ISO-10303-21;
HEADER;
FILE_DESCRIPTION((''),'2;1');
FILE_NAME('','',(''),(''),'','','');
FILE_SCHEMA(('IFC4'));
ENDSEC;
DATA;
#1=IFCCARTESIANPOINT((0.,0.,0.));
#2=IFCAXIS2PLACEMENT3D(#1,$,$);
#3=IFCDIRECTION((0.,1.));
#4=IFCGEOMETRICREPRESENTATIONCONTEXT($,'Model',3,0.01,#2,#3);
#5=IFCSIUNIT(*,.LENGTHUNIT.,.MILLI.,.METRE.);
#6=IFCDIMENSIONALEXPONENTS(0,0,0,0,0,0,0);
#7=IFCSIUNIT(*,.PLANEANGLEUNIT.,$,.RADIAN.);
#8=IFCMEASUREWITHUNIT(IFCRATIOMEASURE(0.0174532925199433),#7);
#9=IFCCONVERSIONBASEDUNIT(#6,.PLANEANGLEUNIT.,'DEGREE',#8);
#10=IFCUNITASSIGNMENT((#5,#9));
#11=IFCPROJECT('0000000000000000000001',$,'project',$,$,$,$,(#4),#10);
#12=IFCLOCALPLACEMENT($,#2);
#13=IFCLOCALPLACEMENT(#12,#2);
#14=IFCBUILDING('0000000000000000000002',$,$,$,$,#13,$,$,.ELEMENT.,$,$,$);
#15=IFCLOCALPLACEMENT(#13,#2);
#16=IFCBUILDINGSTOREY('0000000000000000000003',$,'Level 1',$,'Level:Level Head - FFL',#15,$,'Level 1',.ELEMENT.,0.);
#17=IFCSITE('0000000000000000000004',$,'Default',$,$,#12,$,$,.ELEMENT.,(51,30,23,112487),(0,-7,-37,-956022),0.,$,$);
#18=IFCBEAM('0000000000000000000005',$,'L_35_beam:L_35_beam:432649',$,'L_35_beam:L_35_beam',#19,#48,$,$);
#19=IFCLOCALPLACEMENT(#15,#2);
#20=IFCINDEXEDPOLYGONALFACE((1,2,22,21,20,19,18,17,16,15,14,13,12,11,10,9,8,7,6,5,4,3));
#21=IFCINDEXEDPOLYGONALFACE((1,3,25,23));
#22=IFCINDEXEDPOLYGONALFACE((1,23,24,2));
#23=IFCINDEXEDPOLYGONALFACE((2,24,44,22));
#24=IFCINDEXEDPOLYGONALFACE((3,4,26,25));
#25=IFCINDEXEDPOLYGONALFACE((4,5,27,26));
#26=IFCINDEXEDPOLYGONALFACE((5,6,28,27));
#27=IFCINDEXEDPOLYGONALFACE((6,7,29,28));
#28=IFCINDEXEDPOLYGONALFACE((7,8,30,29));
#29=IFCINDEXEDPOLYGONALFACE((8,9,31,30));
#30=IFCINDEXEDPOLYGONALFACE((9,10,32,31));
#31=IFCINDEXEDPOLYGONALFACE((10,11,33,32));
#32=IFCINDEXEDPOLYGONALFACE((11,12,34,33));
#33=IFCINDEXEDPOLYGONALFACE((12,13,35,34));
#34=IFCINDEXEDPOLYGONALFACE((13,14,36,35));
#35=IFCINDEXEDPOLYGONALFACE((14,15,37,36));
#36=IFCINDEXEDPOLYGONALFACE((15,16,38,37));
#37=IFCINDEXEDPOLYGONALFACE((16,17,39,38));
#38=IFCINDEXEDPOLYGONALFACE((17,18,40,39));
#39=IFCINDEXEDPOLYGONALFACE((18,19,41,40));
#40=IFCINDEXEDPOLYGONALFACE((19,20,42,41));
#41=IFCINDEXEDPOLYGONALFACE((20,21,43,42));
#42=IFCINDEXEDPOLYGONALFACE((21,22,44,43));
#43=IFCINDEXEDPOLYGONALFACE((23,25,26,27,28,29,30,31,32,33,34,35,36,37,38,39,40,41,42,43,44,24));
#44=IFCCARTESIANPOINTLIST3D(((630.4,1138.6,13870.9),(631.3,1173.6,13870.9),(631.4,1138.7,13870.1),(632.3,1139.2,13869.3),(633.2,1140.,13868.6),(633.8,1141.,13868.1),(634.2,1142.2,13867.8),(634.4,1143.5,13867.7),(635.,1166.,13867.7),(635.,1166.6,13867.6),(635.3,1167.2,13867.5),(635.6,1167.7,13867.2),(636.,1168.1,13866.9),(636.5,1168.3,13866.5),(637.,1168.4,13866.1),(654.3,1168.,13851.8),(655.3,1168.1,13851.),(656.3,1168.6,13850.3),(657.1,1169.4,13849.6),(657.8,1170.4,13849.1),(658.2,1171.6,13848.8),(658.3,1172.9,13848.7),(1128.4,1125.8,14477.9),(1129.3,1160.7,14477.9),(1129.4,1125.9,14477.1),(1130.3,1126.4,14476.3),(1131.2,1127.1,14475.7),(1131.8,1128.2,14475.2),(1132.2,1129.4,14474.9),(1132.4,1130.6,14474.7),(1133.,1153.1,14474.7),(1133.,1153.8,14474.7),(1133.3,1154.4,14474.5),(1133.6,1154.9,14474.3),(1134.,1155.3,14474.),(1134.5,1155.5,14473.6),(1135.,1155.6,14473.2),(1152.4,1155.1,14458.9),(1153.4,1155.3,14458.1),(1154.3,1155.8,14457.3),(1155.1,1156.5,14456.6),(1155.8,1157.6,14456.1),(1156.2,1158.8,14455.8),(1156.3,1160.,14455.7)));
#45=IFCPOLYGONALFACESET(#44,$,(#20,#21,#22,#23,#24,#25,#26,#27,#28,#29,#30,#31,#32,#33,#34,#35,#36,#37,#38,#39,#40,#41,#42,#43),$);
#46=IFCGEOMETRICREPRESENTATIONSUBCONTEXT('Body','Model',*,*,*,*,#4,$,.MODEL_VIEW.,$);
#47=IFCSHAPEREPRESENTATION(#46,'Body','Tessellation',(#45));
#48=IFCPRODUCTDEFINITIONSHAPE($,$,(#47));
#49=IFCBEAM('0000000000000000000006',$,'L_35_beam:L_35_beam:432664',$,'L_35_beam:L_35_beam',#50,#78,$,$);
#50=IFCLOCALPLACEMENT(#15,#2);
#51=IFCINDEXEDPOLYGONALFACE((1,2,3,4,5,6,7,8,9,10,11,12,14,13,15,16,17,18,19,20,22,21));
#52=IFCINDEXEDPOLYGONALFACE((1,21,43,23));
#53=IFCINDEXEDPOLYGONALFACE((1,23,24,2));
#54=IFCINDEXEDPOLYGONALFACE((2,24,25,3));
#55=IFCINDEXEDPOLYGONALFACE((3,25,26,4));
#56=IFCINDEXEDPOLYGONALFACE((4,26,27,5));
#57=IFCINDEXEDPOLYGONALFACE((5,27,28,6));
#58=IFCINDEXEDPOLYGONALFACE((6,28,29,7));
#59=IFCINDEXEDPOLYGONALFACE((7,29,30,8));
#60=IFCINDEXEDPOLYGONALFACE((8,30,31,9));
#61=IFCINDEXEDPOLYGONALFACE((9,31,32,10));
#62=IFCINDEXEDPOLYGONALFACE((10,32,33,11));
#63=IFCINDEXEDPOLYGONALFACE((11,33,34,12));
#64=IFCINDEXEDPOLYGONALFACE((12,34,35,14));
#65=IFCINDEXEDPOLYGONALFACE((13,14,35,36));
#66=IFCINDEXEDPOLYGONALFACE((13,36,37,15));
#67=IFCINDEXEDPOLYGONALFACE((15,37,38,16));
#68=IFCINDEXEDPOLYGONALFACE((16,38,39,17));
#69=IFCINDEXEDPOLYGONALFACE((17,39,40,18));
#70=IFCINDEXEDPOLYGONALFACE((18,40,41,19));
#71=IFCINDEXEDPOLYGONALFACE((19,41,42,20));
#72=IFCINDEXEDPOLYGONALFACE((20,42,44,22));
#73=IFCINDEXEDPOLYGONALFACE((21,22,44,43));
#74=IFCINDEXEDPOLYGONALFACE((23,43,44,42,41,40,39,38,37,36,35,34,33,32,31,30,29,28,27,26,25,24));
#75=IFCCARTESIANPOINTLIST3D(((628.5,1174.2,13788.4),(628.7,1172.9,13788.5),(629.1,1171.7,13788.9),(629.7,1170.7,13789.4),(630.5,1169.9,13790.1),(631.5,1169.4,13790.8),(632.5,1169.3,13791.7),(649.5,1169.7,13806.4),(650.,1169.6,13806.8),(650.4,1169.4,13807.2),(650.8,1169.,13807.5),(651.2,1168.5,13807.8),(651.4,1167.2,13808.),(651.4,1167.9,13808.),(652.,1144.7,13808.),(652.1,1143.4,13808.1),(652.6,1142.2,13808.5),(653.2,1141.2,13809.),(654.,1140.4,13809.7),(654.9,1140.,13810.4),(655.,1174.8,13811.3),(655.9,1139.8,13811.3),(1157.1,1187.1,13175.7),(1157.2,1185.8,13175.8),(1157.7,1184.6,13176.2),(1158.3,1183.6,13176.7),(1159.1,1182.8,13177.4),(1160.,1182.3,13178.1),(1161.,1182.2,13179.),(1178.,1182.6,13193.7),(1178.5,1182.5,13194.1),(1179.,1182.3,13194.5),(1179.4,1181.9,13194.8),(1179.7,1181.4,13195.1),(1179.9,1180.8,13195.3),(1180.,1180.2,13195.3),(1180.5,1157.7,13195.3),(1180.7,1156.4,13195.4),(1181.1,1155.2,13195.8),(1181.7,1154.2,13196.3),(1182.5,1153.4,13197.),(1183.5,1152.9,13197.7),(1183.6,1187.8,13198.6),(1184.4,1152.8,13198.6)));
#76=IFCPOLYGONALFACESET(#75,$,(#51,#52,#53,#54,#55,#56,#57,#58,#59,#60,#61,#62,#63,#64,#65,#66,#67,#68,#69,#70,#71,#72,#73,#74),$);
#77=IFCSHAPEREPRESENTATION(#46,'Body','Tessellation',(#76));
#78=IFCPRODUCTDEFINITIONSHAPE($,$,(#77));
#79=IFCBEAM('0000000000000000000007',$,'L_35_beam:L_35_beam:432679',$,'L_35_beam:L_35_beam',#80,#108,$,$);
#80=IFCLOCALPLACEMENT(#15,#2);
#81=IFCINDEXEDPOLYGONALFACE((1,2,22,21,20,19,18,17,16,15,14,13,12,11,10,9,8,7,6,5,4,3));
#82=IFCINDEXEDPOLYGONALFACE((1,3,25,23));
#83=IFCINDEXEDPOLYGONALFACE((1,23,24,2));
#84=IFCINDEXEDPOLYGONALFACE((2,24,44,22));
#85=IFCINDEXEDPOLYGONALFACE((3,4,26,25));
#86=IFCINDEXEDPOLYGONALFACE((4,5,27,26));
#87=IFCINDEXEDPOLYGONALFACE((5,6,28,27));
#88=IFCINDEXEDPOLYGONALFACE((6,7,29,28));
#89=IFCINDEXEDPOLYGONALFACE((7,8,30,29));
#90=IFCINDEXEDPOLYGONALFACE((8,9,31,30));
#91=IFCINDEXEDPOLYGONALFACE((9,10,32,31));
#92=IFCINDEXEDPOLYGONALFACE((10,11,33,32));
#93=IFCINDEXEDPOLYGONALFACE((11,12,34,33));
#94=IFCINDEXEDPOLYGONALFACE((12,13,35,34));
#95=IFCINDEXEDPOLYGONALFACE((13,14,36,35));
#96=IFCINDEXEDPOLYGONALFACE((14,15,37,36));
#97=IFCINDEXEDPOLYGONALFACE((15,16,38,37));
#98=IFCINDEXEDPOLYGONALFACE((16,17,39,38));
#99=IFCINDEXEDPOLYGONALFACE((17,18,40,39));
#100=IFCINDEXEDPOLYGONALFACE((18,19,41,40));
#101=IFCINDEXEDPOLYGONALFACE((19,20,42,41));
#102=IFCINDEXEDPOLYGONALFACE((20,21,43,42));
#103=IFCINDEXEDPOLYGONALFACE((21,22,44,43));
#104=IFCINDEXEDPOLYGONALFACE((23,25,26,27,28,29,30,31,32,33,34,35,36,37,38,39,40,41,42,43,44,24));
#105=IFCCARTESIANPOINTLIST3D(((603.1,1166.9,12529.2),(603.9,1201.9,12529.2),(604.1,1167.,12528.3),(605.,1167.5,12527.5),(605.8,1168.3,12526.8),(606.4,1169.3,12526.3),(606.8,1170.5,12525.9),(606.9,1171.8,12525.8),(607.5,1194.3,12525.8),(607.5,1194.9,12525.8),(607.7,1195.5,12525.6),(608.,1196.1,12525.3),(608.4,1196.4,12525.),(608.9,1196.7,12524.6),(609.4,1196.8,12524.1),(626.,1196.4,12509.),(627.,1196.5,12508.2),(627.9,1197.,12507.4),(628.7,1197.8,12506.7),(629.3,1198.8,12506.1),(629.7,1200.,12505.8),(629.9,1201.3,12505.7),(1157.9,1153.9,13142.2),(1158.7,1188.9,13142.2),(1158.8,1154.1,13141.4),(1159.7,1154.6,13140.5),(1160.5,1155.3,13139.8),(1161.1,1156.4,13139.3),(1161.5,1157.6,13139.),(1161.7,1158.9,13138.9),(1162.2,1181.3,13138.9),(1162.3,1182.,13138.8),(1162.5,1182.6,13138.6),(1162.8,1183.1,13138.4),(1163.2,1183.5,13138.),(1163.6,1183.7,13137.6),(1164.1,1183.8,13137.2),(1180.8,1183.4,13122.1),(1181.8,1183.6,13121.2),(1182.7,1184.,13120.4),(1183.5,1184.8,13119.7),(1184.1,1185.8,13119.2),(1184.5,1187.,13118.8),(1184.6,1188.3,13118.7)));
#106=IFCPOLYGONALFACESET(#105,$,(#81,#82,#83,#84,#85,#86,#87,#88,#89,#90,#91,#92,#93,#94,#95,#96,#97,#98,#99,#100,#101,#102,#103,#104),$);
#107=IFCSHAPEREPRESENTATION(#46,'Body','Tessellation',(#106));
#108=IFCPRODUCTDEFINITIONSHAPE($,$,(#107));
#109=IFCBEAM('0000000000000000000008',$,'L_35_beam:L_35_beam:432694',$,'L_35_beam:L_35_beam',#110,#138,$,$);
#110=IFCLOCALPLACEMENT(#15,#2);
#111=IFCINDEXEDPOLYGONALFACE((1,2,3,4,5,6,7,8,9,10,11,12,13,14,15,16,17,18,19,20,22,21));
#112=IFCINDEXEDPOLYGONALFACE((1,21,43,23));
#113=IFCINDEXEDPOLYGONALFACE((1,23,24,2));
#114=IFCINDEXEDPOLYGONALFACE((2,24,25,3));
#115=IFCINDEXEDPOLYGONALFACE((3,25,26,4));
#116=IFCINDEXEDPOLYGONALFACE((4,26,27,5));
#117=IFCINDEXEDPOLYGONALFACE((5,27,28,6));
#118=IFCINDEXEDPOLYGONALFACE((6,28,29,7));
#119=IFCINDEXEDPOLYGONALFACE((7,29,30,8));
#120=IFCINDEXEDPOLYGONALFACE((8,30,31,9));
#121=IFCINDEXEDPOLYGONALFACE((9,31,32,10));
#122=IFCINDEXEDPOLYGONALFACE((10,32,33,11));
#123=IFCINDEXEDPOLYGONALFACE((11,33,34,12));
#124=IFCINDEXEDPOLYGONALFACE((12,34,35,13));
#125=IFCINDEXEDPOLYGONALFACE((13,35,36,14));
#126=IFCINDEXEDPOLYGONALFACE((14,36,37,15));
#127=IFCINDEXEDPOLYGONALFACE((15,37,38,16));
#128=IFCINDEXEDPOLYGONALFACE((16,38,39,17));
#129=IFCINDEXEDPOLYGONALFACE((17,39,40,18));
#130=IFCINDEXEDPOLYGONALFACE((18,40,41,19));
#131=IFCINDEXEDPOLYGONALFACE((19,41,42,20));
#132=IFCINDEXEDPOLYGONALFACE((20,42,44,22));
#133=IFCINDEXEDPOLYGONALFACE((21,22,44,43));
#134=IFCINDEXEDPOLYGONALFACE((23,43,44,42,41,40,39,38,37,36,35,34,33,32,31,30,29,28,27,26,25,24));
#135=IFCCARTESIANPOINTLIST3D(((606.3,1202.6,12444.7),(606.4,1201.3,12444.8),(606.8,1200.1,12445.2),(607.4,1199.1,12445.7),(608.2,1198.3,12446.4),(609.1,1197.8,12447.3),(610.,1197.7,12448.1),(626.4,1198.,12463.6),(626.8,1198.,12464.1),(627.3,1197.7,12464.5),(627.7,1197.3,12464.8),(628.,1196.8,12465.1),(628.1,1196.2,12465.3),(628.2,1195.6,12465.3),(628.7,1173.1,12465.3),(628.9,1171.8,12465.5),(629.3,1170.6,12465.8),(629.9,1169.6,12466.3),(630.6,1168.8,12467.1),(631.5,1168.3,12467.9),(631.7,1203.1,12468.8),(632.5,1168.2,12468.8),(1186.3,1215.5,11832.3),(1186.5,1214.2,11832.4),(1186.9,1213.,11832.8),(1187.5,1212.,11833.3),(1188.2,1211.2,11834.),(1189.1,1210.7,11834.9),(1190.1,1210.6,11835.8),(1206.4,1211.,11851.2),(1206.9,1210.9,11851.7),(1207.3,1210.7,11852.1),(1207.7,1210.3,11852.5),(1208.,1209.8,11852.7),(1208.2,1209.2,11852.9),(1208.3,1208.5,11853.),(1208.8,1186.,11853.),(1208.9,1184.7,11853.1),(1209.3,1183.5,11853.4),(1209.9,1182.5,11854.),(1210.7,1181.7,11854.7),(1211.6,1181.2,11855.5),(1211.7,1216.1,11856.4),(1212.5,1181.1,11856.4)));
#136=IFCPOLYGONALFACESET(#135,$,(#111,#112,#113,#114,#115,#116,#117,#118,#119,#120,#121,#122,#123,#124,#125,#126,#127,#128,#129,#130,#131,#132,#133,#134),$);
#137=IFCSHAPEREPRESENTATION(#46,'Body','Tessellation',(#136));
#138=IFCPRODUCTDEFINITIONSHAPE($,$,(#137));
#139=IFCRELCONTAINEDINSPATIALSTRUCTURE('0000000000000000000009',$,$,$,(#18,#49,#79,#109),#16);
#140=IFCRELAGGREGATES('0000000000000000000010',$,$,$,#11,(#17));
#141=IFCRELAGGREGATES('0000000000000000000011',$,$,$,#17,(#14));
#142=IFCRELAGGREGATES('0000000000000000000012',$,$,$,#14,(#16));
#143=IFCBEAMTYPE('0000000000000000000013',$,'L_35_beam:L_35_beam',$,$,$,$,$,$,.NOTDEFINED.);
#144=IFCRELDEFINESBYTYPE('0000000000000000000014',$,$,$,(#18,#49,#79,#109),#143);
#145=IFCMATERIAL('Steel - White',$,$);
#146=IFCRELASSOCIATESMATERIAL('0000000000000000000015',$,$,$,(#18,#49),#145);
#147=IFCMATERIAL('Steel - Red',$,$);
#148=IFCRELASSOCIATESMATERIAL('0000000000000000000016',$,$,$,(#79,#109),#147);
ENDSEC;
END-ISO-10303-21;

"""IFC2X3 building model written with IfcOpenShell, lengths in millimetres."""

from ifc_helpers import new_model, entity, si_unit, converted_unit, direction, frame, frame_2d, origin, place, context, subcontext, project, spatial, polyline, circle_curve, parameter, trimmed, segment, composite_curve, outline, extrude, material, type_object, element, save


model = new_model("IFC2X3")

# Units and contexts
model_context = context("Model", 3, precision=0.01, world=origin(), true_north=direction((0.0, 1.0)))
body_context = subcontext(model_context, "Body", "Model", "MODEL_VIEW")
ifc_project = project(units=[si_unit("LENGTHUNIT", "METRE", prefix="MILLI"), converted_unit("PLANEANGLEUNIT", "DEGREE", entity("IfcRatioMeasure", 0.0174532925199433), si_unit("PLANEANGLEUNIT", "RADIAN"), dimensions=[0, 0, 0, 0, 0, 0, 0])], contexts=[model_context])

# Site, building, storey
site_placement = place(None, origin())
site = spatial("IfcSite", under=ifc_project, at=site_placement, Name="Default", CompositionType="ELEMENT", RefLatitude=(51, 30, 23, 112487), RefLongitude=(0, -7, -37, -956022), RefElevation=0.0)
building_placement = place(site_placement, origin())
building = spatial("IfcBuilding", under=site, at=building_placement, CompositionType="ELEMENT")
storey_placement = place(building_placement, origin())
storey = spatial("IfcBuildingStorey", under=building, at=storey_placement, Name="Level 1", ObjectType="Level:Level Head - FFL", LongName="Level 1", CompositionType="ELEMENT", Elevation=0.0)

# Beams
ifc_material_1 = material(Name="Steel - Red")
ifc_material_2 = material(Name="Steel - White")
beam_type_1 = type_object("IfcBeamType", Name="L_35_beam:L_35_beam", PredefinedType="NOTDEFINED")
beam_1_placement = place(storey_placement, frame((618.2, 1181.9, 13827.0), z_axis=(0.773193, 0.013397, -0.634029), x_axis=(0.63417, -0.016334, 0.773021)))
element("IfcBeam", 1, at=beam_1_placement, inside=storey, type_object=beam_type_1, material=ifc_material_2, Name="L_35_beam:L_35_beam:432649", ObjectType="L_35_beam:L_35_beam", context=body_context, shape_type="SweptSolid", body=[
    extrude(outline(composite_curve([segment(polyline([(-4.3, 6.8), (18.2, 6.8)]), True, "CONTINUOUS"), segment(trimmed(circle_curve(frame_2d((18.2, 11.8), x_axis=(0.0, -1.0)), 5.0), [parameter(0.0)], [parameter(90.0)], True, "PARAMETER"), True, "CONTINUOUS"), segment(polyline([(23.2, 11.8), (-11.8, 11.8)]), True, "CONTINUOUS"), segment(polyline([(-11.8, 11.8), (-11.8, -23.2)]), True, "CONTINUOUS"), segment(trimmed(circle_curve(frame_2d((-11.8, -18.2), x_axis=(0.0, -1.0)), 5.0), [parameter(0.0)], [parameter(90.0)], True, "PARAMETER"), True, "CONTINUOUS"), segment(polyline([(-6.8, -18.2), (-6.8, 4.3)]), True, "CONTINUOUS"), segment(trimmed(circle_curve(frame_2d((-4.3, 4.3), x_axis=(-1.0, 0.0)), 2.5), [parameter(270.0)], [parameter(0.0)], True, "PARAMETER"), False, "CONTINUOUS")], self_intersect=False)), frame((42.4, 19.6, -6.4), z_axis=(1.0, 0.0, 0.0), x_axis=(0.0, 0.0333, 0.999445)), (0.0, 0.0, 1.0), 785.3),
])
beam_2_placement = place(storey_placement, frame((618.2, 1181.9, 13827.0), z_axis=(0.757265, -0.013797, 0.652962), x_axis=(0.653107, 0.015997, -0.757096)))
element("IfcBeam", 2, at=beam_2_placement, inside=storey, type_object=beam_type_1, material=ifc_material_2, Name="L_35_beam:L_35_beam:432664", ObjectType="L_35_beam:L_35_beam", context=body_context, shape_type="SweptSolid", body=[
    extrude(outline(composite_curve([segment(polyline([(-23.2, -11.8), (11.8, -11.8)]), True, "CONTINUOUS"), segment(polyline([(11.8, -11.8), (11.8, 23.2)]), True, "CONTINUOUS"), segment(trimmed(circle_curve(frame_2d((11.8, 18.2), x_axis=(0.0, 1.0)), 5.0), [parameter(0.0)], [parameter(90.0)], True, "PARAMETER"), True, "CONTINUOUS"), segment(polyline([(6.8, 18.2), (6.8, -4.3)]), True, "CONTINUOUS"), segment(trimmed(circle_curve(frame_2d((4.3, -4.3), x_axis=(1.0, 0.0)), 2.5), [parameter(270.0)], [parameter(0.0)], True, "PARAMETER"), False, "CONTINUOUS"), segment(polyline([(4.3, -6.8), (-18.2, -6.8)]), True, "CONTINUOUS"), segment(trimmed(circle_curve(frame_2d((-18.2, -11.8), x_axis=(0.0, 1.0)), 5.0), [parameter(0.0)], [parameter(90.0)], True, "PARAMETER"), True, "CONTINUOUS")], self_intersect=False)), frame((35.9, -19.6, 6.4), z_axis=(1.0, 0.0, 0.0), x_axis=(0.0, 0.032335, 0.999477)), (0.0, 0.0, 1.0), 809.3),
])
beam_3_placement = place(storey_placement, frame((589.8, 1210.2, 12487.3), z_axis=(0.741553, 0.014172, -0.670744), x_axis=(0.670894, -0.015665, 0.741388)))
element("IfcBeam", 3, at=beam_3_placement, inside=storey, type_object=beam_type_1, material=ifc_material_1, Name="L_35_beam:L_35_beam:432679", ObjectType="L_35_beam:L_35_beam", context=body_context, shape_type="SweptSolid", body=[
    extrude(outline(composite_curve([segment(polyline([(-4.3, 6.8), (18.2, 6.8)]), True, "CONTINUOUS"), segment(trimmed(circle_curve(frame_2d((18.2, 11.8), x_axis=(0.0, -1.0)), 5.0), [parameter(0.0)], [parameter(90.0)], True, "PARAMETER"), True, "CONTINUOUS"), segment(polyline([(23.2, 11.8), (-11.8, 11.8)]), True, "CONTINUOUS"), segment(polyline([(-11.8, 11.8), (-11.8, -23.2)]), True, "CONTINUOUS"), segment(trimmed(circle_curve(frame_2d((-11.8, -18.2), x_axis=(0.0, -1.0)), 5.0), [parameter(0.0)], [parameter(90.0)], True, "PARAMETER"), True, "CONTINUOUS"), segment(polyline([(-6.8, -18.2), (-6.8, 4.3)]), True, "CONTINUOUS"), segment(trimmed(circle_curve(frame_2d((-4.3, 4.3), x_axis=(-1.0, 0.0)), 2.5), [parameter(270.0)], [parameter(0.0)], True, "PARAMETER"), False, "CONTINUOUS")], self_intersect=False)), frame((40.6, 19.6, -6.3), z_axis=(1.0, 0.0, 0.0), x_axis=(0.0, 0.031479, 0.999504)), (0.0, 0.0, 1.0), 826.9),
])
beam_4_placement = place(storey_placement, frame((589.8, 1210.2, 12487.3), z_axis=(0.726096, -0.014525, 0.68744), x_axis=(0.687593, 0.015339, -0.725934)))
element("IfcBeam", 4, at=beam_4_placement, inside=storey, type_object=beam_type_1, material=ifc_material_1, Name="L_35_beam:L_35_beam:432694", ObjectType="L_35_beam:L_35_beam", context=body_context, shape_type="SweptSolid", body=[
    extrude(outline(composite_curve([segment(polyline([(-23.2, -11.8), (11.8, -11.8)]), True, "CONTINUOUS"), segment(polyline([(11.8, -11.8), (11.8, 23.2)]), True, "CONTINUOUS"), segment(trimmed(circle_curve(frame_2d((11.8, 18.2), x_axis=(0.0, 1.0)), 5.0), [parameter(0.0)], [parameter(90.0)], True, "PARAMETER"), True, "CONTINUOUS"), segment(polyline([(6.8, 18.2), (6.8, -4.3)]), True, "CONTINUOUS"), segment(trimmed(circle_curve(frame_2d((4.3, -4.3), x_axis=(1.0, 0.0)), 2.5), [parameter(270.0)], [parameter(0.0)], True, "PARAMETER"), False, "CONTINUOUS"), segment(polyline([(4.3, -6.8), (-18.2, -6.8)]), True, "CONTINUOUS"), segment(trimmed(circle_curve(frame_2d((-18.2, -11.8), x_axis=(0.0, 1.0)), 5.0), [parameter(0.0)], [parameter(90.0)], True, "PARAMETER"), True, "CONTINUOUS")], self_intersect=False)), frame((42.1, -19.6, 6.3), z_axis=(1.0, 0.0, 0.0), x_axis=(0.0, 0.030715, 0.999528)), (0.0, 0.0, 1.0), 843.6),
])

save(model, "model.ifc")
